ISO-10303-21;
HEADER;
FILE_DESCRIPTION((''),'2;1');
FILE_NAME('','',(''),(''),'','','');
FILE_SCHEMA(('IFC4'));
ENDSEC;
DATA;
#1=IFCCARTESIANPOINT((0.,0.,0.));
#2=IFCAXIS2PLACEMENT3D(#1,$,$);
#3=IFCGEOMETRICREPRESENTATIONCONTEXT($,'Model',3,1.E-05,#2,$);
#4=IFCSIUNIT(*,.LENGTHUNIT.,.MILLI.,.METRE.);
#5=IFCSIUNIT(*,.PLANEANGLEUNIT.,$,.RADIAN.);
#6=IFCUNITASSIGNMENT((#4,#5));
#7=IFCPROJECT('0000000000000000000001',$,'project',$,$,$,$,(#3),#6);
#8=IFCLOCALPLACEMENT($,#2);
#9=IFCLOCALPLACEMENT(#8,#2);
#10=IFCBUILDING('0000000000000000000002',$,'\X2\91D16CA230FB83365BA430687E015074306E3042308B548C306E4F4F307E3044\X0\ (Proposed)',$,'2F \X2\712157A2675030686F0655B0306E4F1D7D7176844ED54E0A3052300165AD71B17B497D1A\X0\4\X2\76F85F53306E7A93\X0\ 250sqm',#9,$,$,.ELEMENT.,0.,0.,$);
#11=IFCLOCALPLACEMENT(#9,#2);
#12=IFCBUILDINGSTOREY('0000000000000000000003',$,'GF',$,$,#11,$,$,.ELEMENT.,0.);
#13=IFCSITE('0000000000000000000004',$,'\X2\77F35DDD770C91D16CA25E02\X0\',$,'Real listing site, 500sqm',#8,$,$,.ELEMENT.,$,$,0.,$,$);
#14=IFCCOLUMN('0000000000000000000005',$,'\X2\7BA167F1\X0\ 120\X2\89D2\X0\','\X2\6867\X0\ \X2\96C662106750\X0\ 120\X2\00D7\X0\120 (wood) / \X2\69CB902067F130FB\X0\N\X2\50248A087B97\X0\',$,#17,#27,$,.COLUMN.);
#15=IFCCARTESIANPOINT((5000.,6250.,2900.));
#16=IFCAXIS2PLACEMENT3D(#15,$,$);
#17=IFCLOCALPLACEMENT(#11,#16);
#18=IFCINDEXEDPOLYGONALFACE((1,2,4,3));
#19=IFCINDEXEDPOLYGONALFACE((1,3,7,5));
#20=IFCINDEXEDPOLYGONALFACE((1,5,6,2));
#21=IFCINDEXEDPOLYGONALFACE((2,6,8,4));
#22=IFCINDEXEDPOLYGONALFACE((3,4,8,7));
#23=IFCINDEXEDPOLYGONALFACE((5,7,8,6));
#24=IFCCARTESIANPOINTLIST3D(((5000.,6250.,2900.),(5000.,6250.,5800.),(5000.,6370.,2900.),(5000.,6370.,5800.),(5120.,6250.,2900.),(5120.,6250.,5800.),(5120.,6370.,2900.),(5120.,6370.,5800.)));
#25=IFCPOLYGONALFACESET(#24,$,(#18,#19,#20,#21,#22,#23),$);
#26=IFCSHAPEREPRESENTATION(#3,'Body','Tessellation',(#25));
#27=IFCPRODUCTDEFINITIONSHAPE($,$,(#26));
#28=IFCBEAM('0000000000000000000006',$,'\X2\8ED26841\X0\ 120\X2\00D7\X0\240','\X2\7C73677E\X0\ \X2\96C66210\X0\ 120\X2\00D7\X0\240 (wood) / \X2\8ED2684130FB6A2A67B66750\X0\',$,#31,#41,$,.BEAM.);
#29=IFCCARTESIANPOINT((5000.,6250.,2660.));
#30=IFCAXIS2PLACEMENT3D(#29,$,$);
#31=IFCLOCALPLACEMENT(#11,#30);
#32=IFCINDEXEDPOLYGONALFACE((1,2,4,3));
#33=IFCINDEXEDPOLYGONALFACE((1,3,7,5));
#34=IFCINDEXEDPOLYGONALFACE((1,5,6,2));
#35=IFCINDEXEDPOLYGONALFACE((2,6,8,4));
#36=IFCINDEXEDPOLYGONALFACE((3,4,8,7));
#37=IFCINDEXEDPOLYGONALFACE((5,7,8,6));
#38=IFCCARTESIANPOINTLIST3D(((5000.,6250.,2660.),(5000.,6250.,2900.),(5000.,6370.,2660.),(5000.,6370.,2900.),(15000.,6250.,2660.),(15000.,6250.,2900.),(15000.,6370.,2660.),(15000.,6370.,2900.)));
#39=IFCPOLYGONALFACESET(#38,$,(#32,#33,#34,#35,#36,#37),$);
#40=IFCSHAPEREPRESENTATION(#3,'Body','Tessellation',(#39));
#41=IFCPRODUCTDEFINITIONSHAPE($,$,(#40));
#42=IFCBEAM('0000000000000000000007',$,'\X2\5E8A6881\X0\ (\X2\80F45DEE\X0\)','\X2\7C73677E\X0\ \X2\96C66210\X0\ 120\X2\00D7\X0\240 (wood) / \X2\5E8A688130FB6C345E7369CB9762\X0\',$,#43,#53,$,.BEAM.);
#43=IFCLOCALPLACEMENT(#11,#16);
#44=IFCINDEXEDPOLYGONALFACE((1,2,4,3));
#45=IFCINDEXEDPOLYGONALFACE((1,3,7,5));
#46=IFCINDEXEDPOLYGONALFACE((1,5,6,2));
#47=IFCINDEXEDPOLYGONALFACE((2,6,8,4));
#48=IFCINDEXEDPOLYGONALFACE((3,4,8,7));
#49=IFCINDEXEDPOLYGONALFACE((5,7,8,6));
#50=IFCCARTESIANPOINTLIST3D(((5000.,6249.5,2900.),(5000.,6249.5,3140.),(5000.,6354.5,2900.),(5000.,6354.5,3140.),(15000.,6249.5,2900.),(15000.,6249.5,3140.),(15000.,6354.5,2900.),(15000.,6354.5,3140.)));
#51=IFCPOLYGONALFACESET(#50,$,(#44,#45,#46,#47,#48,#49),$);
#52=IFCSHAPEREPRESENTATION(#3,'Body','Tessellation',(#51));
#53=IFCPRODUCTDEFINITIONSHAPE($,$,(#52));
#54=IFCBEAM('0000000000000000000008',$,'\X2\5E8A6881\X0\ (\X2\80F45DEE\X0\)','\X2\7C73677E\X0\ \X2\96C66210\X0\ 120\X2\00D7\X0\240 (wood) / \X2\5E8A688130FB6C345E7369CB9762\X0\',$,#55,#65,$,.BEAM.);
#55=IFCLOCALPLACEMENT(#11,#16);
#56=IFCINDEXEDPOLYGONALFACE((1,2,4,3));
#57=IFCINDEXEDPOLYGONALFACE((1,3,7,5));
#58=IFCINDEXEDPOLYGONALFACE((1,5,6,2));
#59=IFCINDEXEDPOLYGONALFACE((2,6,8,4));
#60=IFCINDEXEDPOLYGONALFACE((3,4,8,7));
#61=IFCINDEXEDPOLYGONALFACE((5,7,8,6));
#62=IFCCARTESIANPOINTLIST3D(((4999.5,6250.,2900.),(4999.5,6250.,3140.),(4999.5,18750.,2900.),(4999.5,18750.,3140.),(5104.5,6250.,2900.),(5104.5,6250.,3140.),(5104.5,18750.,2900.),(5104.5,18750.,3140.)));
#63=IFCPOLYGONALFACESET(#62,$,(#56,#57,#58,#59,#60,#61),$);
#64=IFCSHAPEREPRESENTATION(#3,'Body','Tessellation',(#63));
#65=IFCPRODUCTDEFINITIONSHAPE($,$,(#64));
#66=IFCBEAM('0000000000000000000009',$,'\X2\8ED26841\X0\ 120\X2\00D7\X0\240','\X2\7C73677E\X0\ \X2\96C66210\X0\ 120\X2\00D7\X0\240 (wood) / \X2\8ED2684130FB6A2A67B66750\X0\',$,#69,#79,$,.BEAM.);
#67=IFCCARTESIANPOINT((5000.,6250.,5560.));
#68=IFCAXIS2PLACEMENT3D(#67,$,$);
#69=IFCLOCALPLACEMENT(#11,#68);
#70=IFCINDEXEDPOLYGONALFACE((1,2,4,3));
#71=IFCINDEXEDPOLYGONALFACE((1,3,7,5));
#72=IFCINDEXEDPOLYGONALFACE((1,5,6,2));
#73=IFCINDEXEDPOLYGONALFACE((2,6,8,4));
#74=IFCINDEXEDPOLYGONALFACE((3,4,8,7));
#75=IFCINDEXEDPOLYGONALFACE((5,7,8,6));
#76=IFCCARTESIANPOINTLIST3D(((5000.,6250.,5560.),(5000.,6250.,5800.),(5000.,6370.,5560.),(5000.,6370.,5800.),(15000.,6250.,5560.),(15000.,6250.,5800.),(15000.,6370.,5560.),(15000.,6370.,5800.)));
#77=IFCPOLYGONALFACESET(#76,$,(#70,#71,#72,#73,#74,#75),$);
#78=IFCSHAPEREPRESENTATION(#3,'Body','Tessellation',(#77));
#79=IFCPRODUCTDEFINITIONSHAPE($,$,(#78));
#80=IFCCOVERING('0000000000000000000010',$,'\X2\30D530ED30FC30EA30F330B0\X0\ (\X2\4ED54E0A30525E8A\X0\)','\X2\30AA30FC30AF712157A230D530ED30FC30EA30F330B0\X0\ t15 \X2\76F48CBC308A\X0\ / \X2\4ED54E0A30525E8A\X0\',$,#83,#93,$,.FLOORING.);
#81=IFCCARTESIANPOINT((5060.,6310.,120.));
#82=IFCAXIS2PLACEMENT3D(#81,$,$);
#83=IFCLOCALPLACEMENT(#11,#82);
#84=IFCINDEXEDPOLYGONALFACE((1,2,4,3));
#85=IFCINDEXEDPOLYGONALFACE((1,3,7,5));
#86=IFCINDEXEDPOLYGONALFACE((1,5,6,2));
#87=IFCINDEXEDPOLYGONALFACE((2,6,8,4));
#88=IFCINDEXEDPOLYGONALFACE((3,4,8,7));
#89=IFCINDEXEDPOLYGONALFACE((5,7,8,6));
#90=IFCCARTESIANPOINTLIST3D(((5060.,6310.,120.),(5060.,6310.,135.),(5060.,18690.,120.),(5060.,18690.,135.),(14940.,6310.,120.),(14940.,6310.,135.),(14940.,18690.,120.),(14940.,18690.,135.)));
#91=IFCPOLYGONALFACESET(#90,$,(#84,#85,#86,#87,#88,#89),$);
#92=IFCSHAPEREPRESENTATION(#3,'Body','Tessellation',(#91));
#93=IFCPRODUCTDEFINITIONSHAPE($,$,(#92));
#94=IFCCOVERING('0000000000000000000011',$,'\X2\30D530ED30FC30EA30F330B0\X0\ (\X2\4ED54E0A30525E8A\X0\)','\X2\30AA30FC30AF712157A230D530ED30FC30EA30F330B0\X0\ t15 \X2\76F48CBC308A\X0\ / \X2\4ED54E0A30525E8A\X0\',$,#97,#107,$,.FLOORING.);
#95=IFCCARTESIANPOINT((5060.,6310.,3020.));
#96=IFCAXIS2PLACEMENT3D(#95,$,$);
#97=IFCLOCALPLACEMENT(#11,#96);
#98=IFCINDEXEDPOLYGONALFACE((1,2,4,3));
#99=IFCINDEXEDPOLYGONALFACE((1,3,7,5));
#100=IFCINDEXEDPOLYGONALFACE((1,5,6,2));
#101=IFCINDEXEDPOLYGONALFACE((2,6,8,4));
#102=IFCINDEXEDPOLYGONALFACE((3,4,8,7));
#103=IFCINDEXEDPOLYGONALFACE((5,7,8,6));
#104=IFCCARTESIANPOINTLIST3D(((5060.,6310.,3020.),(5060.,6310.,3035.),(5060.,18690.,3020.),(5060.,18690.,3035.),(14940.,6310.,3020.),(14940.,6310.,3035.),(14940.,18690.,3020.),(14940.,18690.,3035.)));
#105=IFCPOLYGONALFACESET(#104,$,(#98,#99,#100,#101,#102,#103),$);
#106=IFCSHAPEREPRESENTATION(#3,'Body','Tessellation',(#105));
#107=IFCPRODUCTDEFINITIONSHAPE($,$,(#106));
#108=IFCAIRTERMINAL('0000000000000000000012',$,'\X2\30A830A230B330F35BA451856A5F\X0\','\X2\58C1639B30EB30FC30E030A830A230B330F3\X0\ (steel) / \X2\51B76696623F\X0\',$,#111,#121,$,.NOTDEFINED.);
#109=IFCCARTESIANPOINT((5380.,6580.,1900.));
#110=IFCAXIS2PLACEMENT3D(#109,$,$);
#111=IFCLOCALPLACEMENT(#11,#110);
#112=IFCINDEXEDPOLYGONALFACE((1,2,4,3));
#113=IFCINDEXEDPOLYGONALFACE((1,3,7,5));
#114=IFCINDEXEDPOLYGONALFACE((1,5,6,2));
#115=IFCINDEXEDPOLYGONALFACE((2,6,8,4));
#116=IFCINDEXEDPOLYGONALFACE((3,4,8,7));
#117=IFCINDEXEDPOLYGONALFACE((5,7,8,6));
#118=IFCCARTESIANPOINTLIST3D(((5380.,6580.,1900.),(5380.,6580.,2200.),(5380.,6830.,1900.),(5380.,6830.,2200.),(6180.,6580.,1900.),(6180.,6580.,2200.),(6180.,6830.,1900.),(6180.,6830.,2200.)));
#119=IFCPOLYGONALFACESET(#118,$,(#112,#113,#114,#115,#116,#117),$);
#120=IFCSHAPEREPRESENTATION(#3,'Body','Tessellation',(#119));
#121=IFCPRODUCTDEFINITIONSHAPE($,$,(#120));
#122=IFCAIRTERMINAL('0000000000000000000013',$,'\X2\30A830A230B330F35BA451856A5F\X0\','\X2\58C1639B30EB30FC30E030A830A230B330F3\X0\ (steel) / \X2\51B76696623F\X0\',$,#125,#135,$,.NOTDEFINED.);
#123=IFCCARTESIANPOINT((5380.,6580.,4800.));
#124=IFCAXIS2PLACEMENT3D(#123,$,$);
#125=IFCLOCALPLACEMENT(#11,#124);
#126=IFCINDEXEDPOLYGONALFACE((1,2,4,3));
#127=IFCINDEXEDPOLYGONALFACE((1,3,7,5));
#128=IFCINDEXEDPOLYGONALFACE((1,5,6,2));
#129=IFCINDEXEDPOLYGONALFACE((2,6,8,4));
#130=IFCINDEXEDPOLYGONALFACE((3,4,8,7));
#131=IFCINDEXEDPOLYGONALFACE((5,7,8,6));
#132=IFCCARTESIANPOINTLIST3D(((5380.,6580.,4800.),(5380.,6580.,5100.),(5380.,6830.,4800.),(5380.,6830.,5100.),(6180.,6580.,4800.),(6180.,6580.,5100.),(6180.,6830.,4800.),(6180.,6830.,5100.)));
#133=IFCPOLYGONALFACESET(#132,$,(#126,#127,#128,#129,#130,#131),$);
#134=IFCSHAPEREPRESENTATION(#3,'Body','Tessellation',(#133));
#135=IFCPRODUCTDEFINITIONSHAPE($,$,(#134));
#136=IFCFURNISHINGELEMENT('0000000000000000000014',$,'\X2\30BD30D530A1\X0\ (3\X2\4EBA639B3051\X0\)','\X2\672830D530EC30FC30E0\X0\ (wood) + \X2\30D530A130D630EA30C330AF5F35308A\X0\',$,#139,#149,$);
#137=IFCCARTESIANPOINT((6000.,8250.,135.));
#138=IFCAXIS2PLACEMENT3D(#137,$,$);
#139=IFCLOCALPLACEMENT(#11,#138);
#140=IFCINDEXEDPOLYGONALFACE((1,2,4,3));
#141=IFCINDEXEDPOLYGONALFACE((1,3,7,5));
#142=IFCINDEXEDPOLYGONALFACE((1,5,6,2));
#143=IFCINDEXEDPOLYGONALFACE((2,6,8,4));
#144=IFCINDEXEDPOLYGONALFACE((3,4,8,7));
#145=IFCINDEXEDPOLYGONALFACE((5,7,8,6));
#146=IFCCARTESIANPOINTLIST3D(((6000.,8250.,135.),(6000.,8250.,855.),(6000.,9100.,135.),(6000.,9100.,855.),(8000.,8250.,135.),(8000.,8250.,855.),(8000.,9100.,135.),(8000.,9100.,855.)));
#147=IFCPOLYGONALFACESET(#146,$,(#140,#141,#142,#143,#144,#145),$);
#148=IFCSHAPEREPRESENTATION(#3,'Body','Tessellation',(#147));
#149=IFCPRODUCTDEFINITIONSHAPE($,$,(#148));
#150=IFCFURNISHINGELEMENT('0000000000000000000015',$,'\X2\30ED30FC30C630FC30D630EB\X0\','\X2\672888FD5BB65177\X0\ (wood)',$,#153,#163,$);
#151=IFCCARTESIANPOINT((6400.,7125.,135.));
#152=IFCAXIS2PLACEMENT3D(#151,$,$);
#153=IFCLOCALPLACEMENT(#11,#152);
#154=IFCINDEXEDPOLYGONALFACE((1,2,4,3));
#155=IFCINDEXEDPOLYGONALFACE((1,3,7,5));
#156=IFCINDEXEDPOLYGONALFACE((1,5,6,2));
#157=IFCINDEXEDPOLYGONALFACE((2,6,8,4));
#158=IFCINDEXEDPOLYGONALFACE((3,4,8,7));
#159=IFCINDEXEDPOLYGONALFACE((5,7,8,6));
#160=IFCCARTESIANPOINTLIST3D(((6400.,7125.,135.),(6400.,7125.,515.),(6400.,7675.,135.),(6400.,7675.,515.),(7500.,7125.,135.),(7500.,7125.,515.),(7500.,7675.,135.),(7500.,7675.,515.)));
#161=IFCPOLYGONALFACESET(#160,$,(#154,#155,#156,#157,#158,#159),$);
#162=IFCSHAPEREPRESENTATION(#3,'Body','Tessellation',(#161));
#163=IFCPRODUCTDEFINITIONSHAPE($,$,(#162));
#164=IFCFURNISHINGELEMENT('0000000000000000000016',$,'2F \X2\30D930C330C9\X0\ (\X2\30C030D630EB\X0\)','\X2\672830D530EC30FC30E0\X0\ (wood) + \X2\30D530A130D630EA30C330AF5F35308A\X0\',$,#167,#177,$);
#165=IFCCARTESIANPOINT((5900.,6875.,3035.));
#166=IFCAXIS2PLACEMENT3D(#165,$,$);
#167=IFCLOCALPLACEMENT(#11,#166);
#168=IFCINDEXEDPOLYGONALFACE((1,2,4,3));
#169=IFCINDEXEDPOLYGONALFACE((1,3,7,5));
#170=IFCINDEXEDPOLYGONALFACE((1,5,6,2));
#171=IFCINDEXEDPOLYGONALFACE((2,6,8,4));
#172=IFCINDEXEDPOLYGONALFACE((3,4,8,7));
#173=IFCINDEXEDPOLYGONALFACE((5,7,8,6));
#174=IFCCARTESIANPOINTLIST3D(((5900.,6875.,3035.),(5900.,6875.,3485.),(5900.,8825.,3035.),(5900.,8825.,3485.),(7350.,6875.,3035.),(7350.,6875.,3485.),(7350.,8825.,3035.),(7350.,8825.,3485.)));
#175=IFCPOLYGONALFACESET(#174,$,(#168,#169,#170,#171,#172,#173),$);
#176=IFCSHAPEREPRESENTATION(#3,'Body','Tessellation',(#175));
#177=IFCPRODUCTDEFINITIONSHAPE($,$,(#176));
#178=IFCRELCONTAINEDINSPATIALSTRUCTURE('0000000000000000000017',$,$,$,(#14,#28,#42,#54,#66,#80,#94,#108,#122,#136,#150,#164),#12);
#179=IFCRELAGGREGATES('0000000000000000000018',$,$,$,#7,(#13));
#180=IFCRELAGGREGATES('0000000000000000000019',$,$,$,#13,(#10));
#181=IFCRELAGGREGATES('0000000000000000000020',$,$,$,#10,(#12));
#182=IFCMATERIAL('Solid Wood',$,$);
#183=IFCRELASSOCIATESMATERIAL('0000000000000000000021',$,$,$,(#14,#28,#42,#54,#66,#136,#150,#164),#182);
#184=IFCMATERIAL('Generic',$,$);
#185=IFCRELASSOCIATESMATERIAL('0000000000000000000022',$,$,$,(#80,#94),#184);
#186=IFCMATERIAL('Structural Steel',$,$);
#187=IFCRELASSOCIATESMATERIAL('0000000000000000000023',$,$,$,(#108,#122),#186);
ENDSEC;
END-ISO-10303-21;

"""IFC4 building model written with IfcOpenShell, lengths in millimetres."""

from ifc_helpers import new_model, si_unit, frame, frame_2d, origin, place, context, project, spatial, rectangle, extrude, material, element, save


model = new_model("IFC4")

# Units and contexts
model_context = context("Model", 3, precision=1e-05, world=origin())
ifc_project = project(units=[si_unit("LENGTHUNIT", "METRE", prefix="MILLI"), si_unit("PLANEANGLEUNIT", "RADIAN")], contexts=[model_context])

# Site, building, storey
site_placement = place(None, origin())
site = spatial("IfcSite", under=ifc_project, at=site_placement, Name="石川県金沢市", ObjectType="Real listing site, 500sqm", CompositionType="ELEMENT", RefElevation=0.0)
building_placement = place(site_placement, origin())
building = spatial("IfcBuilding", under=site, at=building_placement, Name="金沢・茶室と縁側のある和の住まい (Proposed)", ObjectType="2F 無垢材と漆喰の伝統的仕上げ、断熱等級4相当の窓 250sqm", CompositionType="ELEMENT", ElevationOfRefHeight=0.0, ElevationOfTerrain=0.0)
storey_placement = place(building_placement, origin())
storey = spatial("IfcBuildingStorey", under=building, at=storey_placement, Name="GF", CompositionType="ELEMENT", Elevation=0.0)

# Column
ifc_material_1 = material(Name="Solid Wood")
column_1_placement = place(storey_placement, frame((5000.0, 6250.0, 2900.0)))
element("IfcColumn", 1, at=column_1_placement, inside=storey, material=ifc_material_1, Name="管柱 120角", Description="桧 集成材 120×120 (wood) / 構造柱・N値計算", PredefinedType="COLUMN", context=model_context, shape_type="SweptSolid", body=[
    extrude(rectangle(XDim=120.0, YDim=120.0, at=frame_2d((60.0, 60.0))), frame((5000.0, 6250.0, 2900.0)), (0.0, 0.0, 1.0), 2900.0),
])

# Beams
beam_1_placement = place(storey_placement, frame((5000.0, 6250.0, 2660.0)))
element("IfcBeam", 2, at=beam_1_placement, inside=storey, material=ifc_material_1, Name="軒桁 120×240", Description="米松 集成 120×240 (wood) / 軒桁・横架材", PredefinedType="BEAM", context=model_context, shape_type="SweptSolid", body=[
    extrude(rectangle(XDim=10000.0, YDim=120.0, at=frame_2d((5000.0, 60.0))), frame((5000.0, 6250.0, 2660.0)), (0.0, 0.0, 1.0), 240.0),
])
beam_2_placement = place(storey_placement, frame((5000.0, 6250.0, 2900.0)))
element("IfcBeam", 3, at=beam_2_placement, inside=storey, material=ifc_material_1, Name="床梁 (胴差)", Description="米松 集成 120×240 (wood) / 床梁・水平構面", PredefinedType="BEAM", context=model_context, shape_type="SweptSolid", body=[
    extrude(rectangle(XDim=10000.0, YDim=105.0, at=frame_2d((5000.0, 52.0))), frame((5000.0, 6250.0, 2900.0)), (0.0, 0.0, 1.0), 240.0),
])
beam_3_placement = place(storey_placement, frame((5000.0, 6250.0, 2900.0)))
element("IfcBeam", 4, at=beam_3_placement, inside=storey, material=ifc_material_1, Name="床梁 (胴差)", Description="米松 集成 120×240 (wood) / 床梁・水平構面", PredefinedType="BEAM", context=model_context, shape_type="SweptSolid", body=[
    extrude(rectangle(XDim=105.0, YDim=12500.0, at=frame_2d((52.0, 6250.0))), frame((5000.0, 6250.0, 2900.0)), (0.0, 0.0, 1.0), 240.0),
])
beam_4_placement = place(storey_placement, frame((5000.0, 6250.0, 5560.0)))
element("IfcBeam", 5, at=beam_4_placement, inside=storey, material=ifc_material_1, Name="軒桁 120×240", Description="米松 集成 120×240 (wood) / 軒桁・横架材", PredefinedType="BEAM", context=model_context, shape_type="SweptSolid", body=[
    extrude(rectangle(XDim=10000.0, YDim=120.0, at=frame_2d((5000.0, 60.0))), frame((5000.0, 6250.0, 5560.0)), (0.0, 0.0, 1.0), 240.0),
])

# Coverings
ifc_material_2 = material(Name="Generic")
covering_1_placement = place(storey_placement, frame((5060.0, 6310.0, 120.0)))
element("IfcCovering", 6, at=covering_1_placement, inside=storey, material=ifc_material_2, Name="フローリング (仕上げ床)", Description="オーク無垢フローリング t15 直貼り / 仕上げ床", PredefinedType="FLOORING", context=model_context, shape_type="SweptSolid", body=[
    extrude(rectangle(XDim=9880.0, YDim=12380.0, at=frame_2d((4940.0, 6190.0))), frame((5060.0, 6310.0, 120.0)), (0.0, 0.0, 1.0), 15.0),
])
covering_2_placement = place(storey_placement, frame((5060.0, 6310.0, 3020.0)))
element("IfcCovering", 7, at=covering_2_placement, inside=storey, material=ifc_material_2, Name="フローリング (仕上げ床)", Description="オーク無垢フローリング t15 直貼り / 仕上げ床", PredefinedType="FLOORING", context=model_context, shape_type="SweptSolid", body=[
    extrude(rectangle(XDim=9880.0, YDim=12380.0, at=frame_2d((4940.0, 6190.0))), frame((5060.0, 6310.0, 3020.0)), (0.0, 0.0, 1.0), 15.0),
])

# Air terminals
ifc_material_3 = material(Name="Structural Steel")
air_terminal_1_placement = place(storey_placement, frame((5380.0, 6580.0, 1900.0)))
element("IfcAirTerminal", 8, at=air_terminal_1_placement, inside=storey, material=ifc_material_3, Name="エアコン室内機", Description="壁掛ルームエアコン (steel) / 冷暖房", PredefinedType="NOTDEFINED", context=model_context, shape_type="SweptSolid", body=[
    extrude(rectangle(XDim=800.0, YDim=250.0, at=frame_2d((400.0, 125.0))), frame((5380.0, 6580.0, 1900.0)), (0.0, 0.0, 1.0), 300.0),
])
air_terminal_2_placement = place(storey_placement, frame((5380.0, 6580.0, 4800.0)))
element("IfcAirTerminal", 9, at=air_terminal_2_placement, inside=storey, material=ifc_material_3, Name="エアコン室内機", Description="壁掛ルームエアコン (steel) / 冷暖房", PredefinedType="NOTDEFINED", context=model_context, shape_type="SweptSolid", body=[
    extrude(rectangle(XDim=800.0, YDim=250.0, at=frame_2d((400.0, 125.0))), frame((5380.0, 6580.0, 4800.0)), (0.0, 0.0, 1.0), 300.0),
])

# Furnishing elements
furnishing_1_placement = place(storey_placement, frame((6000.0, 8250.0, 135.0)))
element("IfcFurnishingElement", 10, at=furnishing_1_placement, inside=storey, material=ifc_material_1, Name="ソファ (3人掛け)", Description="木フレーム (wood) + ファブリック張り", context=model_context, shape_type="SweptSolid", body=[
    extrude(rectangle(XDim=2000.0, YDim=850.0, at=frame_2d((1000.0, 425.0))), frame((6000.0, 8250.0, 135.0)), (0.0, 0.0, 1.0), 720.0),
])
furnishing_2_placement = place(storey_placement, frame((6400.0, 7125.0, 135.0)))
element("IfcFurnishingElement", 11, at=furnishing_2_placement, inside=storey, material=ifc_material_1, Name="ローテーブル", Description="木製家具 (wood)", context=model_context, shape_type="SweptSolid", body=[
    extrude(rectangle(XDim=1100.0, YDim=550.0, at=frame_2d((550.0, 275.0))), frame((6400.0, 7125.0, 135.0)), (0.0, 0.0, 1.0), 380.0),
])
furnishing_3_placement = place(storey_placement, frame((5900.0, 6875.0, 3035.0)))
element("IfcFurnishingElement", 12, at=furnishing_3_placement, inside=storey, material=ifc_material_1, Name="2F ベッド (ダブル)", Description="木フレーム (wood) + ファブリック張り", context=model_context, shape_type="SweptSolid", body=[
    extrude(rectangle(XDim=1450.0, YDim=1950.0, at=frame_2d((725.0, 975.0))), frame((5900.0, 6875.0, 3035.0)), (0.0, 0.0, 1.0), 450.0),
])

save(model, "model.ifc")
